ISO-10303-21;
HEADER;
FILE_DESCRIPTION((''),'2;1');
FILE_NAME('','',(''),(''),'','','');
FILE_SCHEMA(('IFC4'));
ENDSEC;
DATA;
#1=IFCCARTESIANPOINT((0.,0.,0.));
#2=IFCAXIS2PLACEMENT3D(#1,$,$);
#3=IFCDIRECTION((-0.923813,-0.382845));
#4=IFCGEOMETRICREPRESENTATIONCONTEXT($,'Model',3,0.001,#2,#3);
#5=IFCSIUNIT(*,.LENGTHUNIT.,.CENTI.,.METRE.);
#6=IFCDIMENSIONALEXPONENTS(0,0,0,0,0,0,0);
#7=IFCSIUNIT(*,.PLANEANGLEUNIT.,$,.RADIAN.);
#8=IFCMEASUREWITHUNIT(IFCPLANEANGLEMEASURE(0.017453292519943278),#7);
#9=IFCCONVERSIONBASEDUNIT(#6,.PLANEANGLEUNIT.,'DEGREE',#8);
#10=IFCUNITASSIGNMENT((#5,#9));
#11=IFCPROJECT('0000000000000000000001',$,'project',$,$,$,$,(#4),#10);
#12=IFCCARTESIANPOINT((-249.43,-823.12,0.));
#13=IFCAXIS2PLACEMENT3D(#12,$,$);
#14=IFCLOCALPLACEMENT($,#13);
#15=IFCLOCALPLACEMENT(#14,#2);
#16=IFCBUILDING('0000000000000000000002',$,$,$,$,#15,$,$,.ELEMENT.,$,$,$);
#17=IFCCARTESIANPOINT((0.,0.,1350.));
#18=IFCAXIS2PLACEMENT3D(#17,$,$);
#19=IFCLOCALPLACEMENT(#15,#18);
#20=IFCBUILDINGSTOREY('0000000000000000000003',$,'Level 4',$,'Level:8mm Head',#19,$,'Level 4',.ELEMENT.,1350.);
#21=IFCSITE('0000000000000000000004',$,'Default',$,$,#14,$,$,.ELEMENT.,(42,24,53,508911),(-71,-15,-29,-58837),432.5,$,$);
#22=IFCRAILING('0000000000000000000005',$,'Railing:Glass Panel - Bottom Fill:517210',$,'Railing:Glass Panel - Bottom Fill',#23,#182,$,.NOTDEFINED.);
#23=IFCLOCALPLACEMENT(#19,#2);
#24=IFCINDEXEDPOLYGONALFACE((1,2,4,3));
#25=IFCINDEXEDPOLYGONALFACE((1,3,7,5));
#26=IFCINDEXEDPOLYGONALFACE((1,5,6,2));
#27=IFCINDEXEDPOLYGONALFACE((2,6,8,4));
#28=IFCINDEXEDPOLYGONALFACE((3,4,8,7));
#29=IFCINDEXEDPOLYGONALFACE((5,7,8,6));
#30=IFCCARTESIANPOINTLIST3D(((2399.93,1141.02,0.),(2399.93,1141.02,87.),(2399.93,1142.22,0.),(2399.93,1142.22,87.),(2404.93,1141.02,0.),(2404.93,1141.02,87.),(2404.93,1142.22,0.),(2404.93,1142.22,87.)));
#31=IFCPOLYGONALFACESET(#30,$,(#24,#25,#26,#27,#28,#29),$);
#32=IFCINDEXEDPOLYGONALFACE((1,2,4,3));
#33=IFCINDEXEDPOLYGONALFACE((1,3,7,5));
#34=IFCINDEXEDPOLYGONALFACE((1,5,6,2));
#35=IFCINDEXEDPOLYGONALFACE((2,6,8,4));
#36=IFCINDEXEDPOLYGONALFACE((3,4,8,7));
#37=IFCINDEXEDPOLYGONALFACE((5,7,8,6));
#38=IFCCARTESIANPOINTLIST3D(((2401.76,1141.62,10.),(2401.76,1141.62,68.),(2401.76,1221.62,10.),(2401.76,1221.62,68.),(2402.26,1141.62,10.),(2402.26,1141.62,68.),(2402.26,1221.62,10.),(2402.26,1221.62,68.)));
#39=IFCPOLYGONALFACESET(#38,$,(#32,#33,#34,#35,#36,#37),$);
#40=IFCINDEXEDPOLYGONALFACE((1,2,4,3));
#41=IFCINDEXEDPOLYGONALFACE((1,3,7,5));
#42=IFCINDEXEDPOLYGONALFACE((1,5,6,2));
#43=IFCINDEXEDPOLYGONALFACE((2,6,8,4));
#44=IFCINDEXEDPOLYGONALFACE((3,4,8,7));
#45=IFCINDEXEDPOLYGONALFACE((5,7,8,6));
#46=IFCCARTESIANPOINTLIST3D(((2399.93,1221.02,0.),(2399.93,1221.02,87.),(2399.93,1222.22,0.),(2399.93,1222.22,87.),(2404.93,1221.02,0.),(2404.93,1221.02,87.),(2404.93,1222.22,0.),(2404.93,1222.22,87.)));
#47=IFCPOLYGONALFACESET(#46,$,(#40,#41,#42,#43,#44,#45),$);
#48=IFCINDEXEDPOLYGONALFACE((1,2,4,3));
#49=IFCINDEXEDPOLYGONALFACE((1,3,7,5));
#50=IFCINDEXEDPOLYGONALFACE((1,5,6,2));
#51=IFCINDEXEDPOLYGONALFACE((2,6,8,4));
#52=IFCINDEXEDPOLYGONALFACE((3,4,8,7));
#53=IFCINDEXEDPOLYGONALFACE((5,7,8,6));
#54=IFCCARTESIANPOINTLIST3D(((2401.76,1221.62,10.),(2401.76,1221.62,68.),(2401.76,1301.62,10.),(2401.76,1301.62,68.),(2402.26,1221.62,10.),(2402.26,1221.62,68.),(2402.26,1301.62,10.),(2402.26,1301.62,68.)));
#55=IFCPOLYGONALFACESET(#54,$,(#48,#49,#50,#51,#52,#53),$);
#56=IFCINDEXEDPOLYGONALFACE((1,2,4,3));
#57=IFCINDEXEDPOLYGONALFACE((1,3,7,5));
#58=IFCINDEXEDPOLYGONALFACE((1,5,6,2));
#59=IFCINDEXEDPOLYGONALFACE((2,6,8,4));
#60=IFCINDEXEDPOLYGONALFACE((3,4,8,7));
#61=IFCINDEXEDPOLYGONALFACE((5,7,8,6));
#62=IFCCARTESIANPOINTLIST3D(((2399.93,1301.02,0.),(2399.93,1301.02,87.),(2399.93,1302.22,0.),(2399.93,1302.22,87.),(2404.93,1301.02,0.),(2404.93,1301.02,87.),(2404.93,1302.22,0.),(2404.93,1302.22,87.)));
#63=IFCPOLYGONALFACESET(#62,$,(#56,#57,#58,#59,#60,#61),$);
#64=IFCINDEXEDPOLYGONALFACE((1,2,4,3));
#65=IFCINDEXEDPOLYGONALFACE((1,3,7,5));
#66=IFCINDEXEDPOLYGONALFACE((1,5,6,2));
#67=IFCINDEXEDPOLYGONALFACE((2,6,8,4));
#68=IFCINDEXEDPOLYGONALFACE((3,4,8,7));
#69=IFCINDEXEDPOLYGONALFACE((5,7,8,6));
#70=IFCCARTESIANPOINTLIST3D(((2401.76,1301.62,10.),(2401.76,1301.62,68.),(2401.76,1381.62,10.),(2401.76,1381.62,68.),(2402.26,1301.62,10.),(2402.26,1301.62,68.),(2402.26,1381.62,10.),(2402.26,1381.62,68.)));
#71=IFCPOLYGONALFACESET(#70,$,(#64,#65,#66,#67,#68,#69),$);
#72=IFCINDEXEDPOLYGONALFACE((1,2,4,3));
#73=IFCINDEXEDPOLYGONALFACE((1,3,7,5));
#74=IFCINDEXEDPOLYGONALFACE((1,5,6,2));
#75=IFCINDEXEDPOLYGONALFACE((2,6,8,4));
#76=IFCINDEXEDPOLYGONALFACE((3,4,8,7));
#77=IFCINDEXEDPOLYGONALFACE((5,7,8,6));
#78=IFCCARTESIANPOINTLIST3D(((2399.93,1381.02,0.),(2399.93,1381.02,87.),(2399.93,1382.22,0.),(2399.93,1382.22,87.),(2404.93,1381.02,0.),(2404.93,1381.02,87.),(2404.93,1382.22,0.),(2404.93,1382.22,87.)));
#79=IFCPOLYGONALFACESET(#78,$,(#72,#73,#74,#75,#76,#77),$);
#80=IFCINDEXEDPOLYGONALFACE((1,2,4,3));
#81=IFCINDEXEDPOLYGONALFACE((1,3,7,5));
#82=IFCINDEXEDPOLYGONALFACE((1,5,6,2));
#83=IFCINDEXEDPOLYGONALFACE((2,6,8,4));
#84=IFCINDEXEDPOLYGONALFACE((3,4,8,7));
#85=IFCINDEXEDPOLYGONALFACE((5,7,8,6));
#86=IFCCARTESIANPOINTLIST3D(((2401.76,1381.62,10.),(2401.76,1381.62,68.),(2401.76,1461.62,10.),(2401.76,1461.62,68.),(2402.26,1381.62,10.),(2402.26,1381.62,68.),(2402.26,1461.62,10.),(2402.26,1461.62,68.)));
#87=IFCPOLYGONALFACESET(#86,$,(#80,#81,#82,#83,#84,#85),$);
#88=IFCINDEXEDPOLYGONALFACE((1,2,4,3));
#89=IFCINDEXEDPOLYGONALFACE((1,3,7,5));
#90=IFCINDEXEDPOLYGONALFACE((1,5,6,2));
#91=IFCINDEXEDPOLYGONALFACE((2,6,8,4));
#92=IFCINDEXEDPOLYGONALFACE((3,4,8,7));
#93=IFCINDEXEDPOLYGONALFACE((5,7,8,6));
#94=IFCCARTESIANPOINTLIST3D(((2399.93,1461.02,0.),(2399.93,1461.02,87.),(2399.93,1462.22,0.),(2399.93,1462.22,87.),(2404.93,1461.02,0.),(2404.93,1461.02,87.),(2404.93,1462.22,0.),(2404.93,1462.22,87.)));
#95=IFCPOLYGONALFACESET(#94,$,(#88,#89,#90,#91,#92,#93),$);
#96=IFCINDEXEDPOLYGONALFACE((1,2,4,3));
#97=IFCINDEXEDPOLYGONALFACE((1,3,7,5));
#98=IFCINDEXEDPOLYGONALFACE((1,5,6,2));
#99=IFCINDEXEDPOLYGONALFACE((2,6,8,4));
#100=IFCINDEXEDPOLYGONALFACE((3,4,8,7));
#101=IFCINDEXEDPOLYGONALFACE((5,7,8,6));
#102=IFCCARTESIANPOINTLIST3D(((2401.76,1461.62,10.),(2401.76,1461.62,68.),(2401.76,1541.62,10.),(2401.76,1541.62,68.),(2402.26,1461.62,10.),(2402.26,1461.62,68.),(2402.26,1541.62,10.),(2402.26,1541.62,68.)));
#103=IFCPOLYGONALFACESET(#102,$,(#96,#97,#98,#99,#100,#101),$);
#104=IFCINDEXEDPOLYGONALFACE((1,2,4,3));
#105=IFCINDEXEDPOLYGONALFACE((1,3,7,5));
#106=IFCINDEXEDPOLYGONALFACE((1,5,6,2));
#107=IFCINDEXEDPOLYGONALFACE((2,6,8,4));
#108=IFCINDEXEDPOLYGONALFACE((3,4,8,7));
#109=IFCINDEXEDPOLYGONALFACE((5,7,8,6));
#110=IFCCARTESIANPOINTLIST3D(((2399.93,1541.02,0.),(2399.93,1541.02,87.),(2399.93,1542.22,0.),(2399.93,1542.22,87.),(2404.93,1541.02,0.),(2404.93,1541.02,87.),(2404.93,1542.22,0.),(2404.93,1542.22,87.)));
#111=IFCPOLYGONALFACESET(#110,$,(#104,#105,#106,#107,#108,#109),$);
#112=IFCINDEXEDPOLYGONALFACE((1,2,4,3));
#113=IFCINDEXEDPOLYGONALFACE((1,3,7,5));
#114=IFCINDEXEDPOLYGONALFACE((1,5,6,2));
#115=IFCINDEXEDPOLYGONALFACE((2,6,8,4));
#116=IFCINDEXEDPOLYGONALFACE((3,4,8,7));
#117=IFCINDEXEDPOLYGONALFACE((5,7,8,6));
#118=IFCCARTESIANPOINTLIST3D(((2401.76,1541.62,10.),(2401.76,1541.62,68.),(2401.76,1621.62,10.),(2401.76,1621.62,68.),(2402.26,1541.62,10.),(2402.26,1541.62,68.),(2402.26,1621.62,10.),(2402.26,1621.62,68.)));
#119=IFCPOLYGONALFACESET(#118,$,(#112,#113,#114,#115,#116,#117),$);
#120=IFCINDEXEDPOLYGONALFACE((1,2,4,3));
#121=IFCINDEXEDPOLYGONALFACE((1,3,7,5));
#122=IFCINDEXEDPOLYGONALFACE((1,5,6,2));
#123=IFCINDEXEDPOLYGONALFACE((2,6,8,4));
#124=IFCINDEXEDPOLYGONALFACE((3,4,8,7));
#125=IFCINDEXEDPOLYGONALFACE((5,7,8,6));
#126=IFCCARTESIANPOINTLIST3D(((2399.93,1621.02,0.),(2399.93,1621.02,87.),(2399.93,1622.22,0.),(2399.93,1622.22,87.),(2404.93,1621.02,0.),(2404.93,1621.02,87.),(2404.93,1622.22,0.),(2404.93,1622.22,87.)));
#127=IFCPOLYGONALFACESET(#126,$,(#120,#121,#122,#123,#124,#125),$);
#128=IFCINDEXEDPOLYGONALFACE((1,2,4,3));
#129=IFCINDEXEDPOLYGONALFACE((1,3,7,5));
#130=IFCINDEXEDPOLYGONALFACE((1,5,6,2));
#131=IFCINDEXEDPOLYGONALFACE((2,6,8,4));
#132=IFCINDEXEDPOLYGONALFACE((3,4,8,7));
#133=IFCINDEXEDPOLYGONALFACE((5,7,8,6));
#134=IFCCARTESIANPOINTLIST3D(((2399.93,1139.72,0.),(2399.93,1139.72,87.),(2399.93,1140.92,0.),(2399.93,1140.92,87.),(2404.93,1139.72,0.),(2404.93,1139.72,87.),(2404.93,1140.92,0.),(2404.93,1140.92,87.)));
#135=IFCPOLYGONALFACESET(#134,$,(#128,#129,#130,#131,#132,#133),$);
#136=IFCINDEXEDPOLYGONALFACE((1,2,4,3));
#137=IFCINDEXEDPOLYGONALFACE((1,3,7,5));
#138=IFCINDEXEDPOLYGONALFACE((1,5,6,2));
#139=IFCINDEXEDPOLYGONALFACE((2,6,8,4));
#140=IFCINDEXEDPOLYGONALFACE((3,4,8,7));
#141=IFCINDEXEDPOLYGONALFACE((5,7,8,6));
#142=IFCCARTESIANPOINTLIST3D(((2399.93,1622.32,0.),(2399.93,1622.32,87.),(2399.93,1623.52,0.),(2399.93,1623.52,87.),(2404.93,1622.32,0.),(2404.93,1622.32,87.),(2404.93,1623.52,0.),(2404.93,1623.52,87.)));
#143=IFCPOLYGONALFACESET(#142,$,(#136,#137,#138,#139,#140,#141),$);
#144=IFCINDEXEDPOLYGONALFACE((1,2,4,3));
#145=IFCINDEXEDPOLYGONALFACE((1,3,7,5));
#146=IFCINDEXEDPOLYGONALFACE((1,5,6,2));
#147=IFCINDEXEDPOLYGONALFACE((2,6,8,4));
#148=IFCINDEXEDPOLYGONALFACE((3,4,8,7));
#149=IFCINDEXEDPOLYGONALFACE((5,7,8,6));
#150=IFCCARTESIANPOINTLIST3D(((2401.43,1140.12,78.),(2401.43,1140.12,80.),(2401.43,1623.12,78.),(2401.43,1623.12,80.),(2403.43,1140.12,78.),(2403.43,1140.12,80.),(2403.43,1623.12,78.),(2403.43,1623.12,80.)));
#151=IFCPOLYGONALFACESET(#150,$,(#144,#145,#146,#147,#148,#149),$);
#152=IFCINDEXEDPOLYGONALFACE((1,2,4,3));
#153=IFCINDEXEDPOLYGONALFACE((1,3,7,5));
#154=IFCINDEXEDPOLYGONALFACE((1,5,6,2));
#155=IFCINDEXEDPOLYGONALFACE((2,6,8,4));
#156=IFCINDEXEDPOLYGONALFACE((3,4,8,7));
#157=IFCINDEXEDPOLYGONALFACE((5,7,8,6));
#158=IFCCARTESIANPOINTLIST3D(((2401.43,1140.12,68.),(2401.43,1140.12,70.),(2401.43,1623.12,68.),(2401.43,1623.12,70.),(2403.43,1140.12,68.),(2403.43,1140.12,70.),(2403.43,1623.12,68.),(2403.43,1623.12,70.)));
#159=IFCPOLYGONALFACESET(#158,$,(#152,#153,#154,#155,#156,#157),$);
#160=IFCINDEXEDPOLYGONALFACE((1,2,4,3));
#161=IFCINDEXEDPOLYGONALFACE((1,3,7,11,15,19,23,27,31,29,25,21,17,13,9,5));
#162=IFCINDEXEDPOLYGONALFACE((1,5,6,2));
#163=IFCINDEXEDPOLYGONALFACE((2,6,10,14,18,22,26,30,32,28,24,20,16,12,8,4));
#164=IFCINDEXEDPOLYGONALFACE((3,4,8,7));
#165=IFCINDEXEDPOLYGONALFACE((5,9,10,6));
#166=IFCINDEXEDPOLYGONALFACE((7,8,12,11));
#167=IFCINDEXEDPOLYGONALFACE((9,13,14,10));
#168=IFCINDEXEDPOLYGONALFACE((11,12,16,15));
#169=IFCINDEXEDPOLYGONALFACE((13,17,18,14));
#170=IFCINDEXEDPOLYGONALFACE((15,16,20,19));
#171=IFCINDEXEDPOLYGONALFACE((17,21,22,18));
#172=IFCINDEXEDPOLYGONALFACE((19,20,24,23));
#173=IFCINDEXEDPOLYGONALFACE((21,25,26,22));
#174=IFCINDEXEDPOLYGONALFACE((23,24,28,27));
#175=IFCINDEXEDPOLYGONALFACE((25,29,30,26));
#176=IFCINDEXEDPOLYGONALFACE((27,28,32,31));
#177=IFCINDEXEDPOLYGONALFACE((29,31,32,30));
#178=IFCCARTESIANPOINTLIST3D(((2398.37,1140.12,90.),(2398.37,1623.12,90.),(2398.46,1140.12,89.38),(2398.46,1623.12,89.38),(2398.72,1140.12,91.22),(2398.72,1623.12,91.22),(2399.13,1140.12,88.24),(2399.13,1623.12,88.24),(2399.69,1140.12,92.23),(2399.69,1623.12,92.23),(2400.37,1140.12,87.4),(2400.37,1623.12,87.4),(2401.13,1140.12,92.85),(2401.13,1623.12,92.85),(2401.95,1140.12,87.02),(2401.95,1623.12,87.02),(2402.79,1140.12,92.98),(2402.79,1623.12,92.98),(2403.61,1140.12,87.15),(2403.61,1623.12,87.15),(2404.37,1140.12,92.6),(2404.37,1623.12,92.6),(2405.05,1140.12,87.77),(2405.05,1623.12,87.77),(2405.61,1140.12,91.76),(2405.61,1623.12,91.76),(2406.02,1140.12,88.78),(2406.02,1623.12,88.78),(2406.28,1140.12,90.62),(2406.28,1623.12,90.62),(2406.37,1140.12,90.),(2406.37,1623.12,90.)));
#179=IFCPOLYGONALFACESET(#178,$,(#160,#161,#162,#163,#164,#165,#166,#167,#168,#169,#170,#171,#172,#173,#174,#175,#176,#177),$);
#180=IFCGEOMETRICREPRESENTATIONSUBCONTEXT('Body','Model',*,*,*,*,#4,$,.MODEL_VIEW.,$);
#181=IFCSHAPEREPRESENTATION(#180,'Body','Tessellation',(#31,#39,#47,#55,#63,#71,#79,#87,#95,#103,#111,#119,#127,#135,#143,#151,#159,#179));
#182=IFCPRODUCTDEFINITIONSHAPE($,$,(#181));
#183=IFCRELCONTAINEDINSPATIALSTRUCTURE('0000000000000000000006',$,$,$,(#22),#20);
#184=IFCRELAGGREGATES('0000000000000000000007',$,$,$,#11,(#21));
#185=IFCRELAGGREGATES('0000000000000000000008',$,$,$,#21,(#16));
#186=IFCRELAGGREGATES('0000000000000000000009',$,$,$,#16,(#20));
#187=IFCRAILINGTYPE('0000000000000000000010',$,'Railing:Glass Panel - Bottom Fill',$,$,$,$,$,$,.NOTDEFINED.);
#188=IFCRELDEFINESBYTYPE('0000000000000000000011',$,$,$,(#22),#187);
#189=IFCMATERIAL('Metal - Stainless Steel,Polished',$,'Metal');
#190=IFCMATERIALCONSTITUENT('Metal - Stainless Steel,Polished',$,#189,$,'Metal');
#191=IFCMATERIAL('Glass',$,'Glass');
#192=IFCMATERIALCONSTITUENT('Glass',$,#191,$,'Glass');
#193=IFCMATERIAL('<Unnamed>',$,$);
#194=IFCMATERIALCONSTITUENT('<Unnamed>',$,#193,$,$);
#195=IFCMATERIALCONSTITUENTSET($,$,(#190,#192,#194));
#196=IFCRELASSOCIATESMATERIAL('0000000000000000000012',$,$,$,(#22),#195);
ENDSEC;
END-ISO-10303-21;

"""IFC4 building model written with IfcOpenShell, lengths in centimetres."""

from ifc_helpers import new_model, entity, si_unit, converted_unit, direction, frame, origin, place, context, subcontext, project, spatial, indexed_curve, outline, extrude, material, constituent, constituent_set, type_object, element, save


model = new_model("IFC4")

# Units and contexts
model_context = context("Model", 3, precision=0.001, world=origin(), true_north=direction((-0.923813, -0.382845)))
body_context = subcontext(model_context, "Body", "Model", "MODEL_VIEW")
ifc_project = project(units=[si_unit("LENGTHUNIT", "METRE", prefix="CENTI"), converted_unit("PLANEANGLEUNIT", "DEGREE", entity("IfcPlaneAngleMeasure", 0.017453292519943278), si_unit("PLANEANGLEUNIT", "RADIAN"), dimensions=[0, 0, 0, 0, 0, 0, 0])], contexts=[model_context])

# Site, building, storey
site_placement = place(None, frame((-249.43, -823.12, 0.0)))
site = spatial("IfcSite", under=ifc_project, at=site_placement, Name="Default", CompositionType="ELEMENT", RefLatitude=(42, 24, 53, 508911), RefLongitude=(-71, -15, -29, -58837), RefElevation=432.5)
building_placement = place(site_placement, origin())
building = spatial("IfcBuilding", under=site, at=building_placement, CompositionType="ELEMENT")
storey_placement = place(building_placement, frame((0.0, 0.0, 1350.0)))
storey = spatial("IfcBuildingStorey", under=building, at=storey_placement, Name="Level 4", ObjectType="Level:8mm Head", LongName="Level 4", CompositionType="ELEMENT", Elevation=1350.0)

# Railing
ifc_material_1 = material(Name="Metal - Stainless Steel,Polished", Category="Metal")
ifc_constituent_1 = constituent(ifc_material_1, Name="Metal - Stainless Steel,Polished", Category="Metal")
ifc_material_2 = material(Name="Glass", Category="Glass")
ifc_constituent_2 = constituent(ifc_material_2, Name="Glass", Category="Glass")
ifc_material_3 = material(Name="<Unnamed>")
ifc_constituent_3 = constituent(ifc_material_3, Name="<Unnamed>")
ifc_constituent_set_1 = constituent_set(constituents=[ifc_constituent_1, ifc_constituent_2, ifc_constituent_3])
railing_type = type_object("IfcRailingType", Name="Railing:Glass Panel - Bottom Fill", PredefinedType="NOTDEFINED")
railing_placement = place(storey_placement, origin())
element("IfcRailing", 1, at=railing_placement, inside=storey, type_object=railing_type, material=ifc_constituent_set_1, Name="Railing:Glass Panel - Bottom Fill:517210", ObjectType="Railing:Glass Panel - Bottom Fill", PredefinedType="NOTDEFINED", context=body_context, shape_type="SweptSolid", body=[
    extrude(outline(indexed_curve([(-2.5, -0.6), (2.5, -0.6), (2.5, 0.6), (-2.5, 0.6), (-2.5, -0.6)], self_intersect=False)), frame((2402.43, 1141.62, 0.0), z_axis=(0.0, 0.0, 1.0), x_axis=(-1.0, 0.0, 0.0)), (0.0, 0.0, 1.0), 87.0),
    extrude(outline(indexed_curve([(-0.25, -40.0), (0.25, -40.0), (0.25, 40.0), (-0.25, 40.0), (-0.25, -40.0)], self_intersect=False)), frame((2402.01, 1181.62, 10.0), z_axis=(0.0, 0.0, 1.0), x_axis=(-1.0, 0.0, 0.0)), (0.0, 0.0, 1.0), 58.0),
    extrude(outline(indexed_curve([(-2.5, -0.6), (2.5, -0.6), (2.5, 0.6), (-2.5, 0.6), (-2.5, -0.6)], self_intersect=False)), frame((2402.43, 1221.62, 0.0), z_axis=(0.0, 0.0, 1.0), x_axis=(-1.0, 0.0, 0.0)), (0.0, 0.0, 1.0), 87.0),
    extrude(outline(indexed_curve([(-0.25, -40.0), (0.25, -40.0), (0.25, 40.0), (-0.25, 40.0), (-0.25, -40.0)], self_intersect=False)), frame((2402.01, 1261.62, 10.0), z_axis=(0.0, 0.0, 1.0), x_axis=(-1.0, 0.0, 0.0)), (0.0, 0.0, 1.0), 58.0),
    extrude(outline(indexed_curve([(-2.5, -0.6), (2.5, -0.6), (2.5, 0.6), (-2.5, 0.6), (-2.5, -0.6)], self_intersect=False)), frame((2402.43, 1301.62, 0.0), z_axis=(0.0, 0.0, 1.0), x_axis=(-1.0, 0.0, 0.0)), (0.0, 0.0, 1.0), 87.0),
    extrude(outline(indexed_curve([(-0.25, -40.0), (0.25, -40.0), (0.25, 40.0), (-0.25, 40.0), (-0.25, -40.0)], self_intersect=False)), frame((2402.01, 1341.62, 10.0), z_axis=(0.0, 0.0, 1.0), x_axis=(-1.0, 0.0, 0.0)), (0.0, 0.0, 1.0), 58.0),
    extrude(outline(indexed_curve([(-2.5, -0.6), (2.5, -0.6), (2.5, 0.6), (-2.5, 0.6), (-2.5, -0.6)], self_intersect=False)), frame((2402.43, 1381.62, 0.0), z_axis=(0.0, 0.0, 1.0), x_axis=(-1.0, 0.0, 0.0)), (0.0, 0.0, 1.0), 87.0),
    extrude(outline(indexed_curve([(-0.25, -40.0), (0.25, -40.0), (0.25, 40.0), (-0.25, 40.0), (-0.25, -40.0)], self_intersect=False)), frame((2402.01, 1421.62, 10.0), z_axis=(0.0, 0.0, 1.0), x_axis=(-1.0, 0.0, 0.0)), (0.0, 0.0, 1.0), 58.0),
    extrude(outline(indexed_curve([(-2.5, -0.6), (2.5, -0.6), (2.5, 0.6), (-2.5, 0.6), (-2.5, -0.6)], self_intersect=False)), frame((2402.43, 1461.62, 0.0), z_axis=(0.0, 0.0, 1.0), x_axis=(-1.0, 0.0, 0.0)), (0.0, 0.0, 1.0), 87.0),
    extrude(outline(indexed_curve([(-0.25, -40.0), (0.25, -40.0), (0.25, 40.0), (-0.25, 40.0), (-0.25, -40.0)], self_intersect=False)), frame((2402.01, 1501.62, 10.0), z_axis=(0.0, 0.0, 1.0), x_axis=(-1.0, 0.0, 0.0)), (0.0, 0.0, 1.0), 58.0),
    extrude(outline(indexed_curve([(-2.5, -0.6), (2.5, -0.6), (2.5, 0.6), (-2.5, 0.6), (-2.5, -0.6)], self_intersect=False)), frame((2402.43, 1541.62, 0.0), z_axis=(0.0, 0.0, 1.0), x_axis=(-1.0, 0.0, 0.0)), (0.0, 0.0, 1.0), 87.0),
    extrude(outline(indexed_curve([(-0.25, -40.0), (0.25, -40.0), (0.25, 40.0), (-0.25, 40.0), (-0.25, -40.0)], self_intersect=False)), frame((2402.01, 1581.62, 10.0), z_axis=(0.0, 0.0, 1.0), x_axis=(-1.0, 0.0, 0.0)), (0.0, 0.0, 1.0), 58.0),
    extrude(outline(indexed_curve([(-2.5, -0.6), (2.5, -0.6), (2.5, 0.6), (-2.5, 0.6), (-2.5, -0.6)], self_intersect=False)), frame((2402.43, 1621.62, 0.0), z_axis=(0.0, 0.0, 1.0), x_axis=(-1.0, 0.0, 0.0)), (0.0, 0.0, 1.0), 87.0),
    extrude(outline(indexed_curve([(-2.5, -0.6), (2.5, -0.6), (2.5, 0.6), (-2.5, 0.6), (-2.5, -0.6)], self_intersect=False)), frame((2402.43, 1140.32, 0.0), z_axis=(0.0, 0.0, 1.0), x_axis=(-1.0, 0.0, 0.0)), (0.0, 0.0, 1.0), 87.0),
    extrude(outline(indexed_curve([(-2.5, -0.6), (2.5, -0.6), (2.5, 0.6), (-2.5, 0.6), (-2.5, -0.6)], self_intersect=False)), frame((2402.43, 1622.92, 0.0), z_axis=(0.0, 0.0, 1.0), x_axis=(-1.0, 0.0, 0.0)), (0.0, 0.0, 1.0), 87.0),
    extrude(outline(indexed_curve([(-241.5, -1.0), (241.5, -1.0), (241.5, 1.0), (-241.5, 1.0), (-241.5, -1.0)], self_intersect=False)), frame((2402.43, 1381.62, 78.0), z_axis=(0.0, 0.0, 1.0), x_axis=(0.0, -1.0, 0.0)), (0.0, 0.0, 1.0), 2.0),
    extrude(outline(indexed_curve([(-241.5, -1.0), (241.5, -1.0), (241.5, 1.0), (-241.5, 1.0), (-241.5, -1.0)], self_intersect=False)), frame((2402.43, 1381.62, 68.0), z_axis=(0.0, 0.0, 1.0), x_axis=(0.0, -1.0, 0.0)), (0.0, 0.0, 1.0), 2.0),
    extrude(outline(indexed_curve([(-1.09, -3.85), (0.18, -3.85), (1.42, -3.18), (2.41, -1.97), (2.98, -0.41), (3.04, 1.22), (2.58, 2.63), (1.67, 3.59), (1.09, 3.85), (-0.18, 3.85), (-1.42, 3.18), (-2.41, 1.97), (-2.98, 0.41), (-3.04, -1.22), (-2.58, -2.63), (-1.67, -3.59), (-1.09, -3.85)], self_intersect=False)), frame((2402.37, 1140.12, 90.0), z_axis=(0.0, 1.0, 0.0), x_axis=(-0.27267, 0.0, -0.962108)), (0.0, 0.0, 1.0), 483.0),
])

save(model, "model.ifc")
